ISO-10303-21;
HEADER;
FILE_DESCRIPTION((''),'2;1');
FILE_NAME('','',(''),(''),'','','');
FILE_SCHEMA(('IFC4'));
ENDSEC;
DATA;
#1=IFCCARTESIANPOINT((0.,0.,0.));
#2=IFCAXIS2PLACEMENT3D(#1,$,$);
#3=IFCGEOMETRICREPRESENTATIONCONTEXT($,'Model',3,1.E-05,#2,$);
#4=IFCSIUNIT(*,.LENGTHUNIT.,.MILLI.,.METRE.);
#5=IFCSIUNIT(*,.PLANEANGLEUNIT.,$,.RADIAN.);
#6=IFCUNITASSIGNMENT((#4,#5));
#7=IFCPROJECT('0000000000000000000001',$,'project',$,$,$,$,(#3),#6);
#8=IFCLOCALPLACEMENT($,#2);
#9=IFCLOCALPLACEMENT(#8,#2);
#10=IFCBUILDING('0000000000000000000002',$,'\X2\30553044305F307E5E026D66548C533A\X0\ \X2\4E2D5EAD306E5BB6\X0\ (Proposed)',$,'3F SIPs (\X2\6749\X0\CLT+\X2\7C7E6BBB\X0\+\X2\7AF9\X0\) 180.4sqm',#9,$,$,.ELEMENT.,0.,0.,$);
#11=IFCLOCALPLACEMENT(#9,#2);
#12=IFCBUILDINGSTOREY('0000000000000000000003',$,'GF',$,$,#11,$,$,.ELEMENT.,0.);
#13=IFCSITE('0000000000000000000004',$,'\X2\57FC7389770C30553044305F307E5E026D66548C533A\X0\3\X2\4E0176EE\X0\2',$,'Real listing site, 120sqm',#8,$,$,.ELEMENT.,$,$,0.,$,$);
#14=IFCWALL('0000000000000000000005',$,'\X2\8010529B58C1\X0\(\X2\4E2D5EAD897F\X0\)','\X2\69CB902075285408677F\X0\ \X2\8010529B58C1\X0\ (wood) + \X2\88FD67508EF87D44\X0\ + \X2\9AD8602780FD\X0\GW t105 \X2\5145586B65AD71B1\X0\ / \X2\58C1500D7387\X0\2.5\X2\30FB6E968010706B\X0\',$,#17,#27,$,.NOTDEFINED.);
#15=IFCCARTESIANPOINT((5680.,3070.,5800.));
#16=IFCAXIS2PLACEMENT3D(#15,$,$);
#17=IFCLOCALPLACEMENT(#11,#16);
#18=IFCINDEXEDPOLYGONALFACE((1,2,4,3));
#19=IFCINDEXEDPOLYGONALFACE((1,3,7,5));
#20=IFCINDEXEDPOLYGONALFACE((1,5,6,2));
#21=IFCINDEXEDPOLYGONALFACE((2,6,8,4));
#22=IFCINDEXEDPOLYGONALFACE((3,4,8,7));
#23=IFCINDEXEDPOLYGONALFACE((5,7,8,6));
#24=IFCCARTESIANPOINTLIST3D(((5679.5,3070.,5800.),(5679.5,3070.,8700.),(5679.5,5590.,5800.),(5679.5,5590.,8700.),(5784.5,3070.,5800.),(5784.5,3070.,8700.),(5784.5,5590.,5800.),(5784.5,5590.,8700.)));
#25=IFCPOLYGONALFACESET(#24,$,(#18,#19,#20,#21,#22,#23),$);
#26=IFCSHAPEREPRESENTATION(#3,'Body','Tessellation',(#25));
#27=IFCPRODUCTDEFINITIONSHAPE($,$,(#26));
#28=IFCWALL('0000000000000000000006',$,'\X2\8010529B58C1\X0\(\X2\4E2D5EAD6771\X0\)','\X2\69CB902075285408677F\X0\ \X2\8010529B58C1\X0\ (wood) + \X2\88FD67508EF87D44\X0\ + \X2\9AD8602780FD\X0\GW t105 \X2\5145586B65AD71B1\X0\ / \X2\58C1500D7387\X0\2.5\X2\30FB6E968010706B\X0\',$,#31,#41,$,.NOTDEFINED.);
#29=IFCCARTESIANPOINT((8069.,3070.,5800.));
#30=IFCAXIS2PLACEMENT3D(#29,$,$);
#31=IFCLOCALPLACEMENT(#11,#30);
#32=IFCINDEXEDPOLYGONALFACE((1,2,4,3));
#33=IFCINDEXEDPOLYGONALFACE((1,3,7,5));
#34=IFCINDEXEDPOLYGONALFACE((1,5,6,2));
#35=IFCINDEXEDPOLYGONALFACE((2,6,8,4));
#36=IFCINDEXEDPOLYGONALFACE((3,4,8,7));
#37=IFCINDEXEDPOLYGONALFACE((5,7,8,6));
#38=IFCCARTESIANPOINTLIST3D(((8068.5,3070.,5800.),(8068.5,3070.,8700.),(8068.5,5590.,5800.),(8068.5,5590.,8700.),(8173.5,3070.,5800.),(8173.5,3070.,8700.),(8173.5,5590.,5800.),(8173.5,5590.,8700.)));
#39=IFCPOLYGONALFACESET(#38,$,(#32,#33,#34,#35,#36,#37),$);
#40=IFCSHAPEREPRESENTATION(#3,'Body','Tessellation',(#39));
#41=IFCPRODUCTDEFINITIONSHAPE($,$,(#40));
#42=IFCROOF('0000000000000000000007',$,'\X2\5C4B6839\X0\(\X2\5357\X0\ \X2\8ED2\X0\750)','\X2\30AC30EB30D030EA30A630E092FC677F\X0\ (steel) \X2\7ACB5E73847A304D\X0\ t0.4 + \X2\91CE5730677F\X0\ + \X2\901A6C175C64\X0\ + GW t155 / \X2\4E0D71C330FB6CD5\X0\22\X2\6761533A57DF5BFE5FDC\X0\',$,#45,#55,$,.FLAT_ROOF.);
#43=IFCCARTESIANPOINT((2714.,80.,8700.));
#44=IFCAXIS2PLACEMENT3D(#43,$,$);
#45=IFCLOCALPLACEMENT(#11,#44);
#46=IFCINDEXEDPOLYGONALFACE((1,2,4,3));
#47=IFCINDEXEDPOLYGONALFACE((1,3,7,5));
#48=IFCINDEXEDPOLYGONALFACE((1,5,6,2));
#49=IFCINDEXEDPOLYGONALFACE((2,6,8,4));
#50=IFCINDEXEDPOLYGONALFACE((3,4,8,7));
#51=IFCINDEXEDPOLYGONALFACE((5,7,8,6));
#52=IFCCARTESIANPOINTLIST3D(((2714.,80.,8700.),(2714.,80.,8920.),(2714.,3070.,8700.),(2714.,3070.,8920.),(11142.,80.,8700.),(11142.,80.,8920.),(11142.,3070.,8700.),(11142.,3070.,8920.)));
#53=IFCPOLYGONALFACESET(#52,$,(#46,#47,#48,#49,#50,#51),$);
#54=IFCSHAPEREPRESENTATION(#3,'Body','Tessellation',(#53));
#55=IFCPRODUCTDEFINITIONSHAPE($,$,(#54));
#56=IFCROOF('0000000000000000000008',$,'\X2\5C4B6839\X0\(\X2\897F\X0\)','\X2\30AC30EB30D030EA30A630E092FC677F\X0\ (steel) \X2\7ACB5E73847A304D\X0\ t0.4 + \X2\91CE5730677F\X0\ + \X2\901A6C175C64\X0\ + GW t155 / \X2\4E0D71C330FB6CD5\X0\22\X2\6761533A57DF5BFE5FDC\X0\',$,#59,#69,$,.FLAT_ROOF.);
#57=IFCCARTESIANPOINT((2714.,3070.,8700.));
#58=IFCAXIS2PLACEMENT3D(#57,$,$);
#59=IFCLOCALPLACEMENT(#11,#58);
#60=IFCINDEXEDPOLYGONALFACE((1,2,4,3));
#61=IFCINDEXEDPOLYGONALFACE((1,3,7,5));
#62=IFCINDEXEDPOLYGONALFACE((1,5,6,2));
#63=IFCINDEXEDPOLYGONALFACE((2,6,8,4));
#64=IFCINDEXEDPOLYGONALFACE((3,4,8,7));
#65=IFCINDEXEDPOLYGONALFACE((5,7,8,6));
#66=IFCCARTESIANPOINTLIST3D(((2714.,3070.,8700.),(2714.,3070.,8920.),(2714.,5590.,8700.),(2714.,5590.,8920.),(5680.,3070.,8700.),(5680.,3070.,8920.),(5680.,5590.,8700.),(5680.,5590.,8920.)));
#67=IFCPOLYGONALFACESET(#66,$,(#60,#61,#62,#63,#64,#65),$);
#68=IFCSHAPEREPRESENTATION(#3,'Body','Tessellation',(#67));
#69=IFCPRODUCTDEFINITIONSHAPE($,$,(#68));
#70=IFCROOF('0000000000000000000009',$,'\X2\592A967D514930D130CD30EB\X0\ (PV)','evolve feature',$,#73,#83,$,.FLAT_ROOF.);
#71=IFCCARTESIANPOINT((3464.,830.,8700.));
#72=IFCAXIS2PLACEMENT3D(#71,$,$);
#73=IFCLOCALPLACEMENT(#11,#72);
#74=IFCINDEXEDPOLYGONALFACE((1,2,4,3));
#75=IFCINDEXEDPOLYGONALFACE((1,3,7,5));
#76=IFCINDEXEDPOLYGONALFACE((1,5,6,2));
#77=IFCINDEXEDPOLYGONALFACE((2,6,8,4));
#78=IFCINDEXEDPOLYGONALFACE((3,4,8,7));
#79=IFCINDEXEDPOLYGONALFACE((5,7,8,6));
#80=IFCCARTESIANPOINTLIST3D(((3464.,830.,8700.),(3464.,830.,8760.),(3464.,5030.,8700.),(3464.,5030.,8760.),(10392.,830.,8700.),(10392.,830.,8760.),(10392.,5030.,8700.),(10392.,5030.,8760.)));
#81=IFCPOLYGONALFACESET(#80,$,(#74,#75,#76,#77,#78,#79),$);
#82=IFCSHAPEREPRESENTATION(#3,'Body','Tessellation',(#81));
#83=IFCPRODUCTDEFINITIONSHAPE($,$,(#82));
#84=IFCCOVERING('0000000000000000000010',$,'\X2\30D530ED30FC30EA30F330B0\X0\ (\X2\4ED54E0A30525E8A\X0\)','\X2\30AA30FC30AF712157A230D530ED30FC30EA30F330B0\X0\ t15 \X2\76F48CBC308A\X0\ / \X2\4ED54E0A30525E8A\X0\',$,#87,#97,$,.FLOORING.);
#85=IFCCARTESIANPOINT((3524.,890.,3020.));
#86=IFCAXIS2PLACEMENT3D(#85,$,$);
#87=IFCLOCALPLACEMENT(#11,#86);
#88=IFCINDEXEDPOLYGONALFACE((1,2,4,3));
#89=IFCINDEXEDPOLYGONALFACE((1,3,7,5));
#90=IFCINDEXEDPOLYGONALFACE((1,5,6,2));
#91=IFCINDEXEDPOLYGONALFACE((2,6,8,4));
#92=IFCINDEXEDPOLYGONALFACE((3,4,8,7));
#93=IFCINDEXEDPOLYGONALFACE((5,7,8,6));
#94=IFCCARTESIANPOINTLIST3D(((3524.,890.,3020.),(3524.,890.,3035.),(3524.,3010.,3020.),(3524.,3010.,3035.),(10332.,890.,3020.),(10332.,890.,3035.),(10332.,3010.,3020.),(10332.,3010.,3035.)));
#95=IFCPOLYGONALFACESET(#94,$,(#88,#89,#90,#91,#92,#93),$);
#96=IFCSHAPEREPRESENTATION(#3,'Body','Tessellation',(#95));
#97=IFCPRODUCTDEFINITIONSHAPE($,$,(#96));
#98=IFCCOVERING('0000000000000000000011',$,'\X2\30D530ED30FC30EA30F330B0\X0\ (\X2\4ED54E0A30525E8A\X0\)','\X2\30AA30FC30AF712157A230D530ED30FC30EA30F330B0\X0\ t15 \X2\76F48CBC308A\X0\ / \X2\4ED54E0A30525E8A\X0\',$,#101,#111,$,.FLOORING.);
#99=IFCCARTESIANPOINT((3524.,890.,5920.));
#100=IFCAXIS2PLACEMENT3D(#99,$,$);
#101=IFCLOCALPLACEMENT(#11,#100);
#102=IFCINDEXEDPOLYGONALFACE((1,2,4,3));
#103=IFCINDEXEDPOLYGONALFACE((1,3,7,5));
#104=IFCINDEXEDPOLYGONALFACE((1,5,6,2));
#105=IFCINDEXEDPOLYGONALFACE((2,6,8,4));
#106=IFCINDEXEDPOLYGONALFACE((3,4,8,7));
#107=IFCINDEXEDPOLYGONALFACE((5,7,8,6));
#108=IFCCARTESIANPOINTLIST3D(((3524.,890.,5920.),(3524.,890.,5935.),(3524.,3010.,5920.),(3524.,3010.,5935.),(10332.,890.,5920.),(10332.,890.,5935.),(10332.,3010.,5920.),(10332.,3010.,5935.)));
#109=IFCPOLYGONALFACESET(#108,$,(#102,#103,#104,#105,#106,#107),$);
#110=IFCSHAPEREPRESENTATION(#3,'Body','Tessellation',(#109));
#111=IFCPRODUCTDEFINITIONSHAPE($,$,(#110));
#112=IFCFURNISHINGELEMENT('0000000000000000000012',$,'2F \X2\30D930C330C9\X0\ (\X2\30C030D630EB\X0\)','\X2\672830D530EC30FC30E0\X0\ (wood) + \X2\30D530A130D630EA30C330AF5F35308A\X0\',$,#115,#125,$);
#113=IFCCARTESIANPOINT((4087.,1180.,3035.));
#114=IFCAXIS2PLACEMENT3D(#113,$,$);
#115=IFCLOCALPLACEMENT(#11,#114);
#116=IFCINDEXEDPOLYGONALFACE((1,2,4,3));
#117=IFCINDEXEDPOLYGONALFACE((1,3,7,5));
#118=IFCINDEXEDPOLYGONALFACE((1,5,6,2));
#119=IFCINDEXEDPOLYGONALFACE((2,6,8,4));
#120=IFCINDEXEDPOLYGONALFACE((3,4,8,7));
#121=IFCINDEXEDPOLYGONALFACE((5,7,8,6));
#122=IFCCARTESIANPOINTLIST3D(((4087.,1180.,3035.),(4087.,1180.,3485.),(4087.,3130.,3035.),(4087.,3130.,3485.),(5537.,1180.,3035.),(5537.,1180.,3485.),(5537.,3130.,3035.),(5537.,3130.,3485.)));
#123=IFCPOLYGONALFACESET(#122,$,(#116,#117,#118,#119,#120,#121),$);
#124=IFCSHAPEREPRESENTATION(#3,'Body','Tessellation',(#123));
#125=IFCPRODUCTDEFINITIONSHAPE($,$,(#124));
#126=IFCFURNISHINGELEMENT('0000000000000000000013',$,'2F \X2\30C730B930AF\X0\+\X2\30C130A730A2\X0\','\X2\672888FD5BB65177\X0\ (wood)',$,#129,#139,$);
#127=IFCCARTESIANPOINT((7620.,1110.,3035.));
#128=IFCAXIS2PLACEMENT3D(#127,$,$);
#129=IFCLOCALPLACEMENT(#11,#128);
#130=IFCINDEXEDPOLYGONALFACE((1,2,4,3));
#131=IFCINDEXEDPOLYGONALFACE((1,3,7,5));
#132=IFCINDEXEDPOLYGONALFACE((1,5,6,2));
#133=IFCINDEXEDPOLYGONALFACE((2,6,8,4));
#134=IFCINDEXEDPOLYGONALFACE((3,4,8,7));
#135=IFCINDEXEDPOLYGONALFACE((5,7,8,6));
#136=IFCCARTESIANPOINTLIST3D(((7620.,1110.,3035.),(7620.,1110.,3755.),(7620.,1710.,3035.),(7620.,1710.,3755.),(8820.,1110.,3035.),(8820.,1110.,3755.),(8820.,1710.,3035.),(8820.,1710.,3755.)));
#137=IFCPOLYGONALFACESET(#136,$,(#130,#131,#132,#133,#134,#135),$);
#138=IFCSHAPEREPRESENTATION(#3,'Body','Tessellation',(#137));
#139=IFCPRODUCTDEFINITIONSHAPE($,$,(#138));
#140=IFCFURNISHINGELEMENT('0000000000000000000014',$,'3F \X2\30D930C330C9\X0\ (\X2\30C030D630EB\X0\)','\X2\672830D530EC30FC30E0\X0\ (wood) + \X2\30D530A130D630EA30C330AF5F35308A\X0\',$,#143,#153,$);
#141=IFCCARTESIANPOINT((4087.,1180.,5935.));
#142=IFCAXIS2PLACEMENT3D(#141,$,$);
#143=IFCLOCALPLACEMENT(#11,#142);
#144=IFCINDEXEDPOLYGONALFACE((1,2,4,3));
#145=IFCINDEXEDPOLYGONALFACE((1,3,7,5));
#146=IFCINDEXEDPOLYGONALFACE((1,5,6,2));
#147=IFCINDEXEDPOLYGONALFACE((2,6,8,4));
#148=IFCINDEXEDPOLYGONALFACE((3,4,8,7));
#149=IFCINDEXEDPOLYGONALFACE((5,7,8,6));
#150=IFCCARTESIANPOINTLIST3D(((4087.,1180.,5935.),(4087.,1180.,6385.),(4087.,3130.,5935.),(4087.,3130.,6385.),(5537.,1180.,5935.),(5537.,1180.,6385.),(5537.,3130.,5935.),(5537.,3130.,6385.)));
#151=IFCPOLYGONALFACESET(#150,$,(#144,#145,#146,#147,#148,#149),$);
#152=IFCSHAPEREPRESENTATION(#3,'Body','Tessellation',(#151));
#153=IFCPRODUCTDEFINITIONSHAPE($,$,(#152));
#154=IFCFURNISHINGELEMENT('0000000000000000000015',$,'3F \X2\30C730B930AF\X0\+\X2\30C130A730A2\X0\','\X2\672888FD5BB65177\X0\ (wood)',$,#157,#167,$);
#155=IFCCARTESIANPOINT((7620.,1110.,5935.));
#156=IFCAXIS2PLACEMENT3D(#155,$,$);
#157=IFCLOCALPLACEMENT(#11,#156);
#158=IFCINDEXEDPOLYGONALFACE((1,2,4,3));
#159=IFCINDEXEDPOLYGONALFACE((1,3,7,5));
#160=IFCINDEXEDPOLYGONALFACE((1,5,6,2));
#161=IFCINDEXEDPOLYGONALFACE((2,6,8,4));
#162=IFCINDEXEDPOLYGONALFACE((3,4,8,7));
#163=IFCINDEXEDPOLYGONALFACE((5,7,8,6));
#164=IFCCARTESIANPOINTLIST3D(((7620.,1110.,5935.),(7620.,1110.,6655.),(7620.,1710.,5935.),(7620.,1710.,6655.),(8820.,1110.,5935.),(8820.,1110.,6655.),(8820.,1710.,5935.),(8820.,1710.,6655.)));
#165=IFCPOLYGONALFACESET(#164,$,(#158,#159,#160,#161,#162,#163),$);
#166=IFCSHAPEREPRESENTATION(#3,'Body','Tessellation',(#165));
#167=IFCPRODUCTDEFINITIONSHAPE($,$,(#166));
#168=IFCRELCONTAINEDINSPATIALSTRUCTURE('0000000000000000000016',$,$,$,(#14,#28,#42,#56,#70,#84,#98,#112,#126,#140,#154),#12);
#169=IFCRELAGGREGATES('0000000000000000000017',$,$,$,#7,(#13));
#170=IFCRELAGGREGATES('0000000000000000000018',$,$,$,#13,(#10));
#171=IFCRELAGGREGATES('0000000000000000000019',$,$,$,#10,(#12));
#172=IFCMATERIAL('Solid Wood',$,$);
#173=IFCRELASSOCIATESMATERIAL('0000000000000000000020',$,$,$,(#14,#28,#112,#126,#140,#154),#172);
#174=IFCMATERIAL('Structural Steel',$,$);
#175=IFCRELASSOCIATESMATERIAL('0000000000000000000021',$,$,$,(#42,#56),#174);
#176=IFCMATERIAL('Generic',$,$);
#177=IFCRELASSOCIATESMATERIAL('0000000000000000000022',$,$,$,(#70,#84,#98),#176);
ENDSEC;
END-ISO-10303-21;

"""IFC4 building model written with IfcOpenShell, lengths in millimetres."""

from ifc_helpers import new_model, si_unit, frame, frame_2d, origin, place, context, project, spatial, rectangle, extrude, material, element, save


model = new_model("IFC4")

# Units and contexts
model_context = context("Model", 3, precision=1e-05, world=origin())
ifc_project = project(units=[si_unit("LENGTHUNIT", "METRE", prefix="MILLI"), si_unit("PLANEANGLEUNIT", "RADIAN")], contexts=[model_context])

# Site, building, storey
site_placement = place(None, origin())
site = spatial("IfcSite", under=ifc_project, at=site_placement, Name="埼玉県さいたま市浦和区3丁目2", ObjectType="Real listing site, 120sqm", CompositionType="ELEMENT", RefElevation=0.0)
building_placement = place(site_placement, origin())
building = spatial("IfcBuilding", under=site, at=building_placement, Name="さいたま市浦和区 中庭の家 (Proposed)", ObjectType="3F SIPs (杉CLT+籾殻+竹) 180.4sqm", CompositionType="ELEMENT", ElevationOfRefHeight=0.0, ElevationOfTerrain=0.0)
storey_placement = place(building_placement, origin())
storey = spatial("IfcBuildingStorey", under=building, at=storey_placement, Name="GF", CompositionType="ELEMENT", Elevation=0.0)

# Shared definitions
ifc_material_1 = material(Name="Solid Wood")

# Walls
wall_1_placement = place(storey_placement, frame((5680.0, 3070.0, 5800.0)))
element("IfcWall", 1, at=wall_1_placement, inside=storey, material=ifc_material_1, Name="耐力壁(中庭西)", Description="構造用合板 耐力壁 (wood) + 製材軸組 + 高性能GW t105 充填断熱 / 壁倍率2.5・準耐火", PredefinedType="NOTDEFINED", context=model_context, shape_type="SweptSolid", body=[
    extrude(rectangle(XDim=105.0, YDim=2520.0, at=frame_2d((52.0, 1260.0))), frame((5680.0, 3070.0, 5800.0)), (0.0, 0.0, 1.0), 2900.0),
])
wall_2_placement = place(storey_placement, frame((8069.0, 3070.0, 5800.0)))
element("IfcWall", 2, at=wall_2_placement, inside=storey, material=ifc_material_1, Name="耐力壁(中庭東)", Description="構造用合板 耐力壁 (wood) + 製材軸組 + 高性能GW t105 充填断熱 / 壁倍率2.5・準耐火", PredefinedType="NOTDEFINED", context=model_context, shape_type="SweptSolid", body=[
    extrude(rectangle(XDim=105.0, YDim=2520.0, at=frame_2d((52.0, 1260.0))), frame((8069.0, 3070.0, 5800.0)), (0.0, 0.0, 1.0), 2900.0),
])

# Roofs
ifc_material_2 = material(Name="Structural Steel")
roof_1_placement = place(storey_placement, frame((2714.0, 80.0, 8700.0)))
element("IfcRoof", 3, at=roof_1_placement, inside=storey, material=ifc_material_2, Name="屋根(南 軒750)", Description="ガルバリウム鋼板 (steel) 立平葺き t0.4 + 野地板 + 通気層 + GW t155 / 不燃・法22条区域対応", PredefinedType="FLAT_ROOF", context=model_context, shape_type="SweptSolid", body=[
    extrude(rectangle(XDim=8428.0, YDim=2990.0, at=frame_2d((4214.0, 1495.0))), frame((2714.0, 80.0, 8700.0)), (0.0, 0.0, 1.0), 220.0),
])
roof_2_placement = place(storey_placement, frame((2714.0, 3070.0, 8700.0)))
element("IfcRoof", 4, at=roof_2_placement, inside=storey, material=ifc_material_2, Name="屋根(西)", Description="ガルバリウム鋼板 (steel) 立平葺き t0.4 + 野地板 + 通気層 + GW t155 / 不燃・法22条区域対応", PredefinedType="FLAT_ROOF", context=model_context, shape_type="SweptSolid", body=[
    extrude(rectangle(XDim=2966.0, YDim=2520.0, at=frame_2d((1483.0, 1260.0))), frame((2714.0, 3070.0, 8700.0)), (0.0, 0.0, 1.0), 220.0),
])
ifc_material_3 = material(Name="Generic")
roof_3_placement = place(storey_placement, frame((3464.0, 830.0, 8700.0)))
element("IfcRoof", 5, at=roof_3_placement, inside=storey, material=ifc_material_3, Name="太陽光パネル (PV)", Description="evolve feature", PredefinedType="FLAT_ROOF", context=model_context, shape_type="SweptSolid", body=[
    extrude(rectangle(XDim=6928.0, YDim=4200.0, at=frame_2d((3464.0, 2100.0))), frame((3464.0, 830.0, 8700.0)), (0.0, 0.0, 1.0), 60.0),
])

# Coverings
covering_1_placement = place(storey_placement, frame((3524.0, 890.0, 3020.0)))
element("IfcCovering", 6, at=covering_1_placement, inside=storey, material=ifc_material_3, Name="フローリング (仕上げ床)", Description="オーク無垢フローリング t15 直貼り / 仕上げ床", PredefinedType="FLOORING", context=model_context, shape_type="SweptSolid", body=[
    extrude(rectangle(XDim=6808.0, YDim=2120.0, at=frame_2d((3404.0, 1060.0))), frame((3524.0, 890.0, 3020.0)), (0.0, 0.0, 1.0), 15.0),
])
covering_2_placement = place(storey_placement, frame((3524.0, 890.0, 5920.0)))
element("IfcCovering", 7, at=covering_2_placement, inside=storey, material=ifc_material_3, Name="フローリング (仕上げ床)", Description="オーク無垢フローリング t15 直貼り / 仕上げ床", PredefinedType="FLOORING", context=model_context, shape_type="SweptSolid", body=[
    extrude(rectangle(XDim=6808.0, YDim=2120.0, at=frame_2d((3404.0, 1060.0))), frame((3524.0, 890.0, 5920.0)), (0.0, 0.0, 1.0), 15.0),
])

# Furnishing elements
furnishing_1_placement = place(storey_placement, frame((4087.0, 1180.0, 3035.0)))
element("IfcFurnishingElement", 8, at=furnishing_1_placement, inside=storey, material=ifc_material_1, Name="2F ベッド (ダブル)", Description="木フレーム (wood) + ファブリック張り", context=model_context, shape_type="SweptSolid", body=[
    extrude(rectangle(XDim=1450.0, YDim=1950.0, at=frame_2d((725.0, 975.0))), frame((4087.0, 1180.0, 3035.0)), (0.0, 0.0, 1.0), 450.0),
])
furnishing_2_placement = place(storey_placement, frame((7620.0, 1110.0, 3035.0)))
element("IfcFurnishingElement", 9, at=furnishing_2_placement, inside=storey, material=ifc_material_1, Name="2F デスク+チェア", Description="木製家具 (wood)", context=model_context, shape_type="SweptSolid", body=[
    extrude(rectangle(XDim=1200.0, YDim=600.0, at=frame_2d((600.0, 300.0))), frame((7620.0, 1110.0, 3035.0)), (0.0, 0.0, 1.0), 720.0),
])
furnishing_3_placement = place(storey_placement, frame((4087.0, 1180.0, 5935.0)))
element("IfcFurnishingElement", 10, at=furnishing_3_placement, inside=storey, material=ifc_material_1, Name="3F ベッド (ダブル)", Description="木フレーム (wood) + ファブリック張り", context=model_context, shape_type="SweptSolid", body=[
    extrude(rectangle(XDim=1450.0, YDim=1950.0, at=frame_2d((725.0, 975.0))), frame((4087.0, 1180.0, 5935.0)), (0.0, 0.0, 1.0), 450.0),
])
furnishing_4_placement = place(storey_placement, frame((7620.0, 1110.0, 5935.0)))
element("IfcFurnishingElement", 11, at=furnishing_4_placement, inside=storey, material=ifc_material_1, Name="3F デスク+チェア", Description="木製家具 (wood)", context=model_context, shape_type="SweptSolid", body=[
    extrude(rectangle(XDim=1200.0, YDim=600.0, at=frame_2d((600.0, 300.0))), frame((7620.0, 1110.0, 5935.0)), (0.0, 0.0, 1.0), 720.0),
])

save(model, "model.ifc")
